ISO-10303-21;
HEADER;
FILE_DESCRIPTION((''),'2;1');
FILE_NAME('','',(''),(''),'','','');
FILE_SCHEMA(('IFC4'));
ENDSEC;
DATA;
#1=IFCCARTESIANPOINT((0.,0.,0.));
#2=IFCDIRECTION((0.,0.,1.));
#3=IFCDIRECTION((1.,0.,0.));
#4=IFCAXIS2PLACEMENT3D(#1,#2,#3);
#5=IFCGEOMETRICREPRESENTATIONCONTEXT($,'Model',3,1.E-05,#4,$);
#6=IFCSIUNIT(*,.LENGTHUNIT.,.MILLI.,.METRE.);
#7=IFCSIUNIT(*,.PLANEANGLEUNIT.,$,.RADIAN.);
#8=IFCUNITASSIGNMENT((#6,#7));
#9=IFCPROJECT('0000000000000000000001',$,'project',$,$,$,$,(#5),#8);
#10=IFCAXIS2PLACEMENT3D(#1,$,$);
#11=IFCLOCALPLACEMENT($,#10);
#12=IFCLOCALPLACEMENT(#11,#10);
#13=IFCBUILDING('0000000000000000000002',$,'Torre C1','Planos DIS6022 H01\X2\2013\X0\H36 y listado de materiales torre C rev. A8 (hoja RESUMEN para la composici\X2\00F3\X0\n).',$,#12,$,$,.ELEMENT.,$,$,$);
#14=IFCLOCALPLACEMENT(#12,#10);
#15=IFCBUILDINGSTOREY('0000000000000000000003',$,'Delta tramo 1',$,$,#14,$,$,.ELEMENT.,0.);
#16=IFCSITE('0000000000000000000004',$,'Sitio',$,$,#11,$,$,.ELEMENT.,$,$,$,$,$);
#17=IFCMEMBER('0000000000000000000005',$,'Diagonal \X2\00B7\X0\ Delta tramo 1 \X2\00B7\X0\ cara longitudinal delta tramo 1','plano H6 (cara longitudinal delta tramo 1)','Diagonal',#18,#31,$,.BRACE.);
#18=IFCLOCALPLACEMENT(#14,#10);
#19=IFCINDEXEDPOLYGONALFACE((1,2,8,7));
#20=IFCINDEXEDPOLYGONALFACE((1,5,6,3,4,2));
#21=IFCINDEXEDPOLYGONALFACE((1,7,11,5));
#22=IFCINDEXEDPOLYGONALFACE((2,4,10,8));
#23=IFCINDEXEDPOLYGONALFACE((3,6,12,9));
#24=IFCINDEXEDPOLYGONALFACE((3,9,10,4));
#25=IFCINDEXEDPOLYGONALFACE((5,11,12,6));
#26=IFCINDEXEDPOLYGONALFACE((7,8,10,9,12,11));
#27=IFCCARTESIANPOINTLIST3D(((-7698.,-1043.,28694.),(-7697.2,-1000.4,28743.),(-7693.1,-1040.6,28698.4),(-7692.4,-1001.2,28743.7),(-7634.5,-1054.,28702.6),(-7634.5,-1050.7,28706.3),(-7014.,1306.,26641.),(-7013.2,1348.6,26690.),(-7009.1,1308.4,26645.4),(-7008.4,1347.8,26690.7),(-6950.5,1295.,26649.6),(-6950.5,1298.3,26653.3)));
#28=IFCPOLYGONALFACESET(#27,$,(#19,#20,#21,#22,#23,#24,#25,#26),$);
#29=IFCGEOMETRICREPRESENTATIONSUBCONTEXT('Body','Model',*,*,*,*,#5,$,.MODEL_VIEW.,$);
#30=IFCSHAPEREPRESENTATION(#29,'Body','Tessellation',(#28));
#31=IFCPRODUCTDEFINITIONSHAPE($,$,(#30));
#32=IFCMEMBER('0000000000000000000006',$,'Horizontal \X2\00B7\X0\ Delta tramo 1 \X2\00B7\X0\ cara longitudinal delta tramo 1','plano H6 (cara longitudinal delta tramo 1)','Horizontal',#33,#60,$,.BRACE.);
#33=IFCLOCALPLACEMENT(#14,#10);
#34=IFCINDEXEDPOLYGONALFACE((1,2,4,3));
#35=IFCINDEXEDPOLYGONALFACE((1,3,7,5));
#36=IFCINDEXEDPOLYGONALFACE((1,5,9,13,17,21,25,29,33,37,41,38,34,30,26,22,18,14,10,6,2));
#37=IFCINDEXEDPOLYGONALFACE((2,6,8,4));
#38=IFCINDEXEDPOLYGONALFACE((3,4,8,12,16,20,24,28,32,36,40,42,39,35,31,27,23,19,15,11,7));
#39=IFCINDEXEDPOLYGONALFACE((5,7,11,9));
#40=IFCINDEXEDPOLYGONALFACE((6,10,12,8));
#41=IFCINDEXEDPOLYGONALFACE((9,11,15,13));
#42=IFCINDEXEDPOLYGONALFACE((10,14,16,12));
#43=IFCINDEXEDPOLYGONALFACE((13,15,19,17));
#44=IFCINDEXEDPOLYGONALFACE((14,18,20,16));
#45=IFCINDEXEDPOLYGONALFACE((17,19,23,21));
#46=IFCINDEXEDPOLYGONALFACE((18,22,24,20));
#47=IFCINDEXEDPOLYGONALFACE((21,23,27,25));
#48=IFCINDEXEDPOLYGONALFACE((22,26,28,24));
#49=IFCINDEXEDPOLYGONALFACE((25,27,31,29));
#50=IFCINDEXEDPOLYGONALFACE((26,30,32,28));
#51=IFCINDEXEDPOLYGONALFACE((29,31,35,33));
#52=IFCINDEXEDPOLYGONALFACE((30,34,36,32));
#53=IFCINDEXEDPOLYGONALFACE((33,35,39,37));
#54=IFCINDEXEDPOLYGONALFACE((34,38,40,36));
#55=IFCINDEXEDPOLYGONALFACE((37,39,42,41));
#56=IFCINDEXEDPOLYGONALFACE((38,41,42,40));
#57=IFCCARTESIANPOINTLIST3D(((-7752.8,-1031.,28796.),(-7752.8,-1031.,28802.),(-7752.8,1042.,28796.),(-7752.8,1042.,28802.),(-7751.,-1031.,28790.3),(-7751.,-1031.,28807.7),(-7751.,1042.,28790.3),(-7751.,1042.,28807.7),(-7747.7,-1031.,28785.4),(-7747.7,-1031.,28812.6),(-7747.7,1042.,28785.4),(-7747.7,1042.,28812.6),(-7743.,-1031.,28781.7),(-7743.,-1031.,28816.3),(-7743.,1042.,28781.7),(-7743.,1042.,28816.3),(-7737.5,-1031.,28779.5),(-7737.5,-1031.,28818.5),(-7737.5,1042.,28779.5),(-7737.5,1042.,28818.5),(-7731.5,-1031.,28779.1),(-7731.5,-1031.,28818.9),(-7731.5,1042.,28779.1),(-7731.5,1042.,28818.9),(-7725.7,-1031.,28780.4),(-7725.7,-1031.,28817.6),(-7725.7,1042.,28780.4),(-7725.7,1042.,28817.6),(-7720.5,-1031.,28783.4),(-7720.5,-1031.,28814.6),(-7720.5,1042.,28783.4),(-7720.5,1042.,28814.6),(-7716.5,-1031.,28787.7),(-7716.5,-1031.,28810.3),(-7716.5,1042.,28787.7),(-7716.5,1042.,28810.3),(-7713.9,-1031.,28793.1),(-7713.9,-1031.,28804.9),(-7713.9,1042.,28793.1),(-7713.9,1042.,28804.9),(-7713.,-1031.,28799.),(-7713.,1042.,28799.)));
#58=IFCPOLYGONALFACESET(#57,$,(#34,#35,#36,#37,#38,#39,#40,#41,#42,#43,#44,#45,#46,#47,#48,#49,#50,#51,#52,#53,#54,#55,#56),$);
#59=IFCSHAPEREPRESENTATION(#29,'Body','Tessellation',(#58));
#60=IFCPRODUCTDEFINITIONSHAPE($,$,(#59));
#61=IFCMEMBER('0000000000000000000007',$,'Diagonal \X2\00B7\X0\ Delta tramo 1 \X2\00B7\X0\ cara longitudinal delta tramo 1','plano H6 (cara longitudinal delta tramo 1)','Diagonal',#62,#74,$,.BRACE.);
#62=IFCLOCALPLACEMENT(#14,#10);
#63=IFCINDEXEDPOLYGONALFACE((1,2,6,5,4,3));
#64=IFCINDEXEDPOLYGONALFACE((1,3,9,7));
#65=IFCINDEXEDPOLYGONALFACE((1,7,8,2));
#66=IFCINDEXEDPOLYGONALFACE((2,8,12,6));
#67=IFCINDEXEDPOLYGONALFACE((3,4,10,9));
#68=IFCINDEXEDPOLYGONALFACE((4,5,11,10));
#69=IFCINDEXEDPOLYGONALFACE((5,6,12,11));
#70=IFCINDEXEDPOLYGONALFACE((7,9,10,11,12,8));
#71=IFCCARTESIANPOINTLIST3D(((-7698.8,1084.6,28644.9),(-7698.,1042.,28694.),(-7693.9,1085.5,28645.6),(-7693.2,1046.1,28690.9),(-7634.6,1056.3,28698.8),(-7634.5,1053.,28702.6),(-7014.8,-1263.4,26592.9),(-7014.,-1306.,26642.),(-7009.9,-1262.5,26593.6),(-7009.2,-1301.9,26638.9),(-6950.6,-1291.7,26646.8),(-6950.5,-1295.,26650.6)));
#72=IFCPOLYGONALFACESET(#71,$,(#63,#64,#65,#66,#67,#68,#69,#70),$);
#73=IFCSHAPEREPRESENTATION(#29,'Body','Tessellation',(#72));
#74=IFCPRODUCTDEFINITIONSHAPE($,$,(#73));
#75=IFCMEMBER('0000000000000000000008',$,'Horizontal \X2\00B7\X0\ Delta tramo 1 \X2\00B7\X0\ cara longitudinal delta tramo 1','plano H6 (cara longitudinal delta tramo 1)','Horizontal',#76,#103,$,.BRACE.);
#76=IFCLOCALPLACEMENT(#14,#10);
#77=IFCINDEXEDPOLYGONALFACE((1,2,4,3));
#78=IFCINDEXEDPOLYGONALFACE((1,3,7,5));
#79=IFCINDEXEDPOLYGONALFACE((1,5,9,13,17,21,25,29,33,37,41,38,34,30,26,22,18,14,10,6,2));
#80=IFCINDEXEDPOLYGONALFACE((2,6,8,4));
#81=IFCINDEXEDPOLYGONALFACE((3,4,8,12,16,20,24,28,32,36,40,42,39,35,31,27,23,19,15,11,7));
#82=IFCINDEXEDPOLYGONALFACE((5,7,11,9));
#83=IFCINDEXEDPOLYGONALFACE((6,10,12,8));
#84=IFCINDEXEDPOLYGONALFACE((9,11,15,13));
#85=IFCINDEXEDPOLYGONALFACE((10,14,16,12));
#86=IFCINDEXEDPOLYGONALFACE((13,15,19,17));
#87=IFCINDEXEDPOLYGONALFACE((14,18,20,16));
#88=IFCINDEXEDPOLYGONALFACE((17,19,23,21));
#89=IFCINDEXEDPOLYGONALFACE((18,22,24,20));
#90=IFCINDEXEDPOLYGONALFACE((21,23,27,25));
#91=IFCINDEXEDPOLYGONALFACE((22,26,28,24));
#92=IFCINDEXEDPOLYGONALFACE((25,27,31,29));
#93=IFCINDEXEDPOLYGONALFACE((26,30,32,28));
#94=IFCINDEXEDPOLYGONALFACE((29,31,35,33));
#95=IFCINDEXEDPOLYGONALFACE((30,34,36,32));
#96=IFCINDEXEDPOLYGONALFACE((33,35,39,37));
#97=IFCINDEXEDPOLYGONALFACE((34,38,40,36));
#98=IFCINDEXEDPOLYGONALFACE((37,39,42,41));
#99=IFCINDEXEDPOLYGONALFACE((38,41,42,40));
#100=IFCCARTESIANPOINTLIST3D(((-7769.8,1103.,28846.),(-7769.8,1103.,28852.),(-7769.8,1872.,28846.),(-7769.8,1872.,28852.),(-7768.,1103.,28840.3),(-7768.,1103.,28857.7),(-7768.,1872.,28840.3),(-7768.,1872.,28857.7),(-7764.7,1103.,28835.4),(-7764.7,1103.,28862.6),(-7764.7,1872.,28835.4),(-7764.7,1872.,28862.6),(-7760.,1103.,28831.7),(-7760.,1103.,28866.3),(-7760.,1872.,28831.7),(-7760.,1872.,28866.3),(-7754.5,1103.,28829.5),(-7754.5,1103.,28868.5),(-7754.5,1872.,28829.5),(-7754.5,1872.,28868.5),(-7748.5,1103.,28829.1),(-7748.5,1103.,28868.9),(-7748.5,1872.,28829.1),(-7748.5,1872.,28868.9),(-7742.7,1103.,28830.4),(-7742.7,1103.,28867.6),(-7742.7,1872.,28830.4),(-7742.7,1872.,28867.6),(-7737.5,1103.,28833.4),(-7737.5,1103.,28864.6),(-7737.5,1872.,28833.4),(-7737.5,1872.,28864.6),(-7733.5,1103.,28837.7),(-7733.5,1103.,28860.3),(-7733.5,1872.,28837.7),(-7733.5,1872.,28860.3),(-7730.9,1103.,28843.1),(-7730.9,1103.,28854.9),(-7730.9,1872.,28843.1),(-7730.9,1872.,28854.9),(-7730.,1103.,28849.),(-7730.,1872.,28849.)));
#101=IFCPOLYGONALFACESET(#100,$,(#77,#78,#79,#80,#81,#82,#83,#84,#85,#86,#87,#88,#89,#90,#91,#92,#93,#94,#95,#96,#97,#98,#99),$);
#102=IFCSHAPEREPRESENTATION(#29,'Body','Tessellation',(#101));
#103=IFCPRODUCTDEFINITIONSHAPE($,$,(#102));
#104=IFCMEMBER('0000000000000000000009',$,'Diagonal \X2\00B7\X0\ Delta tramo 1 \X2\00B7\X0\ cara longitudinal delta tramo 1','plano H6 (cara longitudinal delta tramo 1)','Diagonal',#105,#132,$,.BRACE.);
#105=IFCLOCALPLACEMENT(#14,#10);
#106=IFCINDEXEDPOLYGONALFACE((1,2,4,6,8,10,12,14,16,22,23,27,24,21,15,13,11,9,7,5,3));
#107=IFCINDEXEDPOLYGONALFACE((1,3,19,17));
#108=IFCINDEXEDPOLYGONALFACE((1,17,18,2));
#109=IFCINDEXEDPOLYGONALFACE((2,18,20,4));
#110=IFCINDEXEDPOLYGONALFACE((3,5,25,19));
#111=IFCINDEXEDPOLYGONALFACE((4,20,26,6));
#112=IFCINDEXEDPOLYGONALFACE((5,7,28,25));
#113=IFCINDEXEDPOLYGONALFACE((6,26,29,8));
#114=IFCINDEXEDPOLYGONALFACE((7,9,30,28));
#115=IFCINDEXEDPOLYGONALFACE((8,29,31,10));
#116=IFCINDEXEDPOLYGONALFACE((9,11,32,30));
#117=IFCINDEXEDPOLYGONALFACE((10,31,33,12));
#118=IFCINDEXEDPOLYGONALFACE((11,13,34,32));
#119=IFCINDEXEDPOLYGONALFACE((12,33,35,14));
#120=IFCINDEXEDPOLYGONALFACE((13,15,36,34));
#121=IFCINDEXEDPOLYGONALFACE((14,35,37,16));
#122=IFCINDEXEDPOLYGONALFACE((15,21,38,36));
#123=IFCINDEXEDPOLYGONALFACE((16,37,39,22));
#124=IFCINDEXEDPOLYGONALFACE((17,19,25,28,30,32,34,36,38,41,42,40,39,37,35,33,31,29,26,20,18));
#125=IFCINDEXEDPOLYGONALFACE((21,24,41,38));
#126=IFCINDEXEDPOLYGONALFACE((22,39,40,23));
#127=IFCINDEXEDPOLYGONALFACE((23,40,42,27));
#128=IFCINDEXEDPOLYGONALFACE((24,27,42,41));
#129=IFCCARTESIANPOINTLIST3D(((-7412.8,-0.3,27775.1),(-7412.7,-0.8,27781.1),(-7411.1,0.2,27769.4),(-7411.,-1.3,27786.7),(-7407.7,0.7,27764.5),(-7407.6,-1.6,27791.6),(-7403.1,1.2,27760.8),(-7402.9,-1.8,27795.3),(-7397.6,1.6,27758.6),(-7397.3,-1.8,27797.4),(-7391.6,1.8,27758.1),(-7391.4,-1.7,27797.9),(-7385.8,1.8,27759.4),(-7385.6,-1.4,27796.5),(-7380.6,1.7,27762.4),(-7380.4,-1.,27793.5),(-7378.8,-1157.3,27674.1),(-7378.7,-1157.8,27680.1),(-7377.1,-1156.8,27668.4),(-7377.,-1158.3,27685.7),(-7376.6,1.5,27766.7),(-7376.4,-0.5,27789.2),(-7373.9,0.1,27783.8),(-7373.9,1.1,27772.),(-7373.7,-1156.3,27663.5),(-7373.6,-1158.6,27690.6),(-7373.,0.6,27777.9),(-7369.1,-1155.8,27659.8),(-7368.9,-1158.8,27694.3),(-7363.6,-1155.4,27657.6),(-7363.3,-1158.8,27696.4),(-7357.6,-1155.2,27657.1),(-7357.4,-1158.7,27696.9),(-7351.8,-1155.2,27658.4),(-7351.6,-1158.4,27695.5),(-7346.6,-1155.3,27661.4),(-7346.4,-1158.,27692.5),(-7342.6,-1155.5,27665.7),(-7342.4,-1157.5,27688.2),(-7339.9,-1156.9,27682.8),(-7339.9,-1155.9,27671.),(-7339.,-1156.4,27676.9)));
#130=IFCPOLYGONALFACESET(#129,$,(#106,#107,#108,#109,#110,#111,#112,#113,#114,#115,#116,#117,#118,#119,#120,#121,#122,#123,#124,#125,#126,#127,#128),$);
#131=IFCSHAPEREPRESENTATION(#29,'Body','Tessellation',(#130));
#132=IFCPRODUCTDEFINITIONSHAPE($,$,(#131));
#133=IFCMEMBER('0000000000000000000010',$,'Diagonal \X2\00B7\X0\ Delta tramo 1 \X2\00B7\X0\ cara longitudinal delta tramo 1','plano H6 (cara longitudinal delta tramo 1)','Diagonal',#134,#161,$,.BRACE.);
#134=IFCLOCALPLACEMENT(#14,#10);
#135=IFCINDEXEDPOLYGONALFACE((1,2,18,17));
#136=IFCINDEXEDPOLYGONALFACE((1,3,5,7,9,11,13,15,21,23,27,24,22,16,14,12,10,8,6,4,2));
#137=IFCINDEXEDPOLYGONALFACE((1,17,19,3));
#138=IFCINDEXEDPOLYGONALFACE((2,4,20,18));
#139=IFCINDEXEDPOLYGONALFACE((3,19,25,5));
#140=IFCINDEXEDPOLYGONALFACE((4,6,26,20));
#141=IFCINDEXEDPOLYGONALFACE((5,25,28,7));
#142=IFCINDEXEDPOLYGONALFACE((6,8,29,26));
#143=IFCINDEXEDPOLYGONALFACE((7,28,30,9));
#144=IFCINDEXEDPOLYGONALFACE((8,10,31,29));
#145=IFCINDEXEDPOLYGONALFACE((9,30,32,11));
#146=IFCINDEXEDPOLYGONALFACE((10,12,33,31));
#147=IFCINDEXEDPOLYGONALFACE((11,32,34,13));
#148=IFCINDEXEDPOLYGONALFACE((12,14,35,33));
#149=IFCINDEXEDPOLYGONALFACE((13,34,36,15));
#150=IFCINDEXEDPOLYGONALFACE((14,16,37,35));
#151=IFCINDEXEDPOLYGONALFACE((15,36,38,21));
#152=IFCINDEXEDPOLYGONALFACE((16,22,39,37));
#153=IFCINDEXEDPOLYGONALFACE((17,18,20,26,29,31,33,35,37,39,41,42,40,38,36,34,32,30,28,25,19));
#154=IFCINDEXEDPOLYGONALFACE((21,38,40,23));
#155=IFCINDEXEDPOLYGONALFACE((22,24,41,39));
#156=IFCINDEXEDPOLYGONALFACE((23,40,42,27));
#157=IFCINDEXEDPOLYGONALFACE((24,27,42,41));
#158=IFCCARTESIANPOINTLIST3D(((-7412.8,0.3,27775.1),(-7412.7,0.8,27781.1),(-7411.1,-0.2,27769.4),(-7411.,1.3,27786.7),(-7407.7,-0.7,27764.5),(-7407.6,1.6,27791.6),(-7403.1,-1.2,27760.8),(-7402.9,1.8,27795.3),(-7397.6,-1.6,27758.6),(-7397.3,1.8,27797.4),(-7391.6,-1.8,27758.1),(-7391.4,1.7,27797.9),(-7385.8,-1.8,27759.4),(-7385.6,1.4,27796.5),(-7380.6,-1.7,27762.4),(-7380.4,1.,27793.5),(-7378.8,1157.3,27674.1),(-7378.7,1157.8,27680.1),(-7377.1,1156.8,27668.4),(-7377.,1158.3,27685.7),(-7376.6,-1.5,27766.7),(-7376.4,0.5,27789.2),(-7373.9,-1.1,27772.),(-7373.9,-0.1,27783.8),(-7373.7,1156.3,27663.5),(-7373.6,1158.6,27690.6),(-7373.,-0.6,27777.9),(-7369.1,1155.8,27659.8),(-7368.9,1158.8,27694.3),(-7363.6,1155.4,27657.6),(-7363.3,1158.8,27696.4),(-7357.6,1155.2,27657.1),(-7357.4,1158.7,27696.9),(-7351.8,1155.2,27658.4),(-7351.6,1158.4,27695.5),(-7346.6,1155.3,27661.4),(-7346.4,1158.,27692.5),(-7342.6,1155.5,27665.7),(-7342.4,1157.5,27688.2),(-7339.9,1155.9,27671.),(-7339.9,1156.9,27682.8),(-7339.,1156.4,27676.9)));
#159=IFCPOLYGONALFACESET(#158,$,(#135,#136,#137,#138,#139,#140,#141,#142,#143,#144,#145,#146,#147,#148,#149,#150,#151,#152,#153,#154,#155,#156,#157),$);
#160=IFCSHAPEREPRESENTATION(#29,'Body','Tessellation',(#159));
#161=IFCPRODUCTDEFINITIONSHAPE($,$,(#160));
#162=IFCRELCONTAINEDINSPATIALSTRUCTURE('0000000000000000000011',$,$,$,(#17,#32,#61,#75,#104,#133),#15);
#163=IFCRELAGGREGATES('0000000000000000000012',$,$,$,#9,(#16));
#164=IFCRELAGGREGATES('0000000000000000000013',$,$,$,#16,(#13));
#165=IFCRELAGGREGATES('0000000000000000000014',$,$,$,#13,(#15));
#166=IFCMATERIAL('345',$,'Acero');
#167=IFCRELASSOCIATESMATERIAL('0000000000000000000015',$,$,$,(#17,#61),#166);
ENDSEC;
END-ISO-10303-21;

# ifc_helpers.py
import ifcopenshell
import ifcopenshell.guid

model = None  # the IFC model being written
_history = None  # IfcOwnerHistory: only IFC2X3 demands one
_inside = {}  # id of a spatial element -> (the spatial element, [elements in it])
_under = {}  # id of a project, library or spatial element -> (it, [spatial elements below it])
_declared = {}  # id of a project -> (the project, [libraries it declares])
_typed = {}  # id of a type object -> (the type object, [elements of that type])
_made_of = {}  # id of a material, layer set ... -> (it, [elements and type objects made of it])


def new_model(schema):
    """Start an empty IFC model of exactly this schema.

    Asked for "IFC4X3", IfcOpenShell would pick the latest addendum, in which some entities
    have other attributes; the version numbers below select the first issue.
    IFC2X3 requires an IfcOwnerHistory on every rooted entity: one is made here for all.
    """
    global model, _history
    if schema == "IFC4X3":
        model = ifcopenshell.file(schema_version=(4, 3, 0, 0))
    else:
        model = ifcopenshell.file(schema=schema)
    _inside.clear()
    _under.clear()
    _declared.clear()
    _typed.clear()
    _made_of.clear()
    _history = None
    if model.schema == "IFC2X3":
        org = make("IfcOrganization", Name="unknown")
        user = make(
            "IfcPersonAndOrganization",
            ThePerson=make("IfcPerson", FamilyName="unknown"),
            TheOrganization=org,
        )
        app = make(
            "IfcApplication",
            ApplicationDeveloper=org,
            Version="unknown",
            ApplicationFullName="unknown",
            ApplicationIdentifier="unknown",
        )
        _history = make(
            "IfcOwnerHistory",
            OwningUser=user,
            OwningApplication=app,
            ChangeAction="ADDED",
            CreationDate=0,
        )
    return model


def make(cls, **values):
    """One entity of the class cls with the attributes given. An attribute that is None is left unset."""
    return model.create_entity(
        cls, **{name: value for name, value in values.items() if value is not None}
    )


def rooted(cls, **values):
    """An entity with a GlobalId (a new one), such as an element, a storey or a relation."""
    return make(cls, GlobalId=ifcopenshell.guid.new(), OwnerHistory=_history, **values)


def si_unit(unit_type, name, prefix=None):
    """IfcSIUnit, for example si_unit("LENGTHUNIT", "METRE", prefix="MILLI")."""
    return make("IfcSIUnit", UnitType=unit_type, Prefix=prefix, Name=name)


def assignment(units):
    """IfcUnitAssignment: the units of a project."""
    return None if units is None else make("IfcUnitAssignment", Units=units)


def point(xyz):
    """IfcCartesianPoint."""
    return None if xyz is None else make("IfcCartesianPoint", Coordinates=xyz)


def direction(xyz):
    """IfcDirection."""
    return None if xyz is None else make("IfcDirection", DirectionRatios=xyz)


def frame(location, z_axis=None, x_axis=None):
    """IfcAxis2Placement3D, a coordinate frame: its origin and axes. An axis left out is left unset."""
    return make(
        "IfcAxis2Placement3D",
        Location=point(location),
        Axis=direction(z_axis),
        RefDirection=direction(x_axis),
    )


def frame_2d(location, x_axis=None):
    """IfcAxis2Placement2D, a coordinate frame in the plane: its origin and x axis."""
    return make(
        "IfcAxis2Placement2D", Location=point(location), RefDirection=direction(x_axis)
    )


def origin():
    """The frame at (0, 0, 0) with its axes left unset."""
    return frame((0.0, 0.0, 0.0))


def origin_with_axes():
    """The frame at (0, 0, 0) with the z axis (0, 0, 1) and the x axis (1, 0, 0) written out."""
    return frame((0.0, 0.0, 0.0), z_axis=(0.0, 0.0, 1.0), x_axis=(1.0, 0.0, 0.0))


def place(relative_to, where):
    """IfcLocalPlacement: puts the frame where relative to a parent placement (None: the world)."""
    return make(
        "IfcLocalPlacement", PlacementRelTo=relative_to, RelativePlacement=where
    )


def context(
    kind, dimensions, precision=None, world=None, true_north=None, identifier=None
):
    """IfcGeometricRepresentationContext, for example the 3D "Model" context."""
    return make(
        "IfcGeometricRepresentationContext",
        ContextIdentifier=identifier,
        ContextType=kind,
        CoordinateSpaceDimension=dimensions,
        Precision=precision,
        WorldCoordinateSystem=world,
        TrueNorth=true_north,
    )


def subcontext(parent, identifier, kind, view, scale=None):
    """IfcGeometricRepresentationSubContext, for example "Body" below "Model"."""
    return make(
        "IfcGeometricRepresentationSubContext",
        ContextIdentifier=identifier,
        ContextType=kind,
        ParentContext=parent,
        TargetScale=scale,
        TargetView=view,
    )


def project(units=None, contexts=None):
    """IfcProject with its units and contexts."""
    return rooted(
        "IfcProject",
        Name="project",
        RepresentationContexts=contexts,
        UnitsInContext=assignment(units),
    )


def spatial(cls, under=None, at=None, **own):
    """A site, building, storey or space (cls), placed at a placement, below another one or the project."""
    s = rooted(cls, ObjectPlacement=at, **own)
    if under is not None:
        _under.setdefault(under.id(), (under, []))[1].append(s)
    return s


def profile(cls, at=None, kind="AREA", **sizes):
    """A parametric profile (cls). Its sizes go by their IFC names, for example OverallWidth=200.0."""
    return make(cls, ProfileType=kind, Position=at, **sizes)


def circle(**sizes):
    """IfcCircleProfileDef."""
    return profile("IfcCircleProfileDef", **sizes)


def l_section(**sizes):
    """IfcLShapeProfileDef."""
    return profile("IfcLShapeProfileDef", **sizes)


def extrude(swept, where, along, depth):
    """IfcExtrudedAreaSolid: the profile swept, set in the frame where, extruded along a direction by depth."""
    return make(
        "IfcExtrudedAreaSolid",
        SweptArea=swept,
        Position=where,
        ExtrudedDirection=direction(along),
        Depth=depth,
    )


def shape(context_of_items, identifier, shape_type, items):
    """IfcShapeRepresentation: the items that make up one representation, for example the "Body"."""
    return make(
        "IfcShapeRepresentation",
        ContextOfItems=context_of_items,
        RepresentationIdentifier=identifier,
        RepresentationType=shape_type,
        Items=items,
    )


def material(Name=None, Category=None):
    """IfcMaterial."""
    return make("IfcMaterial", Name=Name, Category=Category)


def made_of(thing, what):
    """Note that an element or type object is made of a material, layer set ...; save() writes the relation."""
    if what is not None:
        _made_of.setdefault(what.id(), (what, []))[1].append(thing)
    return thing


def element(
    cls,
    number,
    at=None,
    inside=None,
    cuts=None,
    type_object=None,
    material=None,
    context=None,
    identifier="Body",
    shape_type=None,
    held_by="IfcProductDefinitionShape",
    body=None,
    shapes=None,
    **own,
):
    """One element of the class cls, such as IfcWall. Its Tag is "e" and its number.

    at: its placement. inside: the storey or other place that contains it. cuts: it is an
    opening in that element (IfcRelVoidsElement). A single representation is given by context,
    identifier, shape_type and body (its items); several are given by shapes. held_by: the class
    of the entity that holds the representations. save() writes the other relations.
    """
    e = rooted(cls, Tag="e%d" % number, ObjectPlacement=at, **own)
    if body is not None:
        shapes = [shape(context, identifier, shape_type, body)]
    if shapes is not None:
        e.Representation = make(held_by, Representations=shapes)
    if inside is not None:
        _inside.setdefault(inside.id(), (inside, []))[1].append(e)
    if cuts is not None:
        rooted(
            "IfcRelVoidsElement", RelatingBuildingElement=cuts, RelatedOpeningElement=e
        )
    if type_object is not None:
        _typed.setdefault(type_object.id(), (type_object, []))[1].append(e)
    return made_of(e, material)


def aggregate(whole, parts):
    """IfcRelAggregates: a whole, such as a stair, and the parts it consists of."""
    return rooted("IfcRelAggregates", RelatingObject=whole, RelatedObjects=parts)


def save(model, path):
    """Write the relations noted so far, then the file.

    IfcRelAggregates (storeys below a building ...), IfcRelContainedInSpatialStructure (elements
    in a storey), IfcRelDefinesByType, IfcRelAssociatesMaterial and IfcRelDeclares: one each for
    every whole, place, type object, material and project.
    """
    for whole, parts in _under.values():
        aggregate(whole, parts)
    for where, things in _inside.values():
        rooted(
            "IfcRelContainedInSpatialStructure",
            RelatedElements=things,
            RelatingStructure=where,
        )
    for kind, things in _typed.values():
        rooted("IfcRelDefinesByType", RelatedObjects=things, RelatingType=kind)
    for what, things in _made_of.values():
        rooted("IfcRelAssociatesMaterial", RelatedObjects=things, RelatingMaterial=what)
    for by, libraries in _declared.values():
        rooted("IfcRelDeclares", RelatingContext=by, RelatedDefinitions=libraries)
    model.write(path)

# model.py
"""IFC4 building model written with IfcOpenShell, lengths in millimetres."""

from ifc_helpers import new_model, si_unit, frame, frame_2d, origin, origin_with_axes, place, context, subcontext, project, spatial, circle, l_section, extrude, material, element, save


model = new_model("IFC4")

# Units and contexts
model_context = context("Model", 3, precision=1e-05, world=origin_with_axes())
body_context = subcontext(model_context, "Body", "Model", "MODEL_VIEW")
ifc_project = project(units=[si_unit("LENGTHUNIT", "METRE", prefix="MILLI"), si_unit("PLANEANGLEUNIT", "RADIAN")], contexts=[model_context])

# Site, building, storey
site_placement = place(None, origin())
site = spatial("IfcSite", under=ifc_project, at=site_placement, Name="Sitio", CompositionType="ELEMENT")
building_placement = place(site_placement, origin())
building = spatial("IfcBuilding", under=site, at=building_placement, Name="Torre C1", Description="Planos DIS6022 H01–H36 y listado de materiales torre C rev. A8 (hoja RESUMEN para la composición).", CompositionType="ELEMENT")
storey_placement = place(building_placement, origin())
storey = spatial("IfcBuildingStorey", under=building, at=storey_placement, Name="Delta tramo 1", CompositionType="ELEMENT", Elevation=0.0)

# Members
ifc_material = material(Name="345", Category="Acero")
member_1_placement = place(storey_placement, frame((-7014.0, 1306.0, 26641.0), z_axis=(-0.214164, -0.735484, 0.642805), x_axis=(0.976727, -0.169145, 0.131884)))
element("IfcMember", 1, at=member_1_placement, inside=storey, material=ifc_material, Name="Diagonal · Delta tramo 1 · cara longitudinal delta tramo 1", Description="plano H6 (cara longitudinal delta tramo 1)", ObjectType="Diagonal", PredefinedType="BRACE", context=body_context, shape_type="SweptSolid", body=[
    extrude(l_section(Depth=65.0, Width=65.0, Thickness=5.0, at=frame_2d((32.5, 32.5))), None, (0.0, 0.0, 1.0), 3193.8),
])
member_2_placement = place(storey_placement, frame((-7733.0, -1031.0, 28799.0), z_axis=(0.0, 1.0, 0.0), x_axis=(1.0, 0.0, 0.0)))
element("IfcMember", 2, at=member_2_placement, inside=storey, Name="Horizontal · Delta tramo 1 · cara longitudinal delta tramo 1", Description="plano H6 (cara longitudinal delta tramo 1)", ObjectType="Horizontal", PredefinedType="BRACE", context=body_context, shape_type="SweptSolid", body=[
    extrude(circle(Radius=20.0), None, (0.0, 0.0, 1.0), 2073.0),
])
member_3_placement = place(storey_placement, frame((-7014.0, -1306.0, 26642.0), z_axis=(-0.214256, 0.735488, 0.642769), x_axis=(0.976707, 0.169249, 0.131906)))
element("IfcMember", 3, at=member_3_placement, inside=storey, material=ifc_material, Name="Diagonal · Delta tramo 1 · cara longitudinal delta tramo 1", Description="plano H6 (cara longitudinal delta tramo 1)", ObjectType="Diagonal", PredefinedType="BRACE", context=body_context, shape_type="SweptSolid", body=[
    extrude(l_section(Depth=65.0, Width=65.0, Thickness=5.0, at=frame_2d((32.5, 32.5))), None, (0.0, 0.0, 1.0), 3192.4),
])
member_4_placement = place(storey_placement, frame((-7750.0, 1103.0, 28849.0), z_axis=(0.0, 1.0, 0.0), x_axis=(1.0, 0.0, 0.0)))
element("IfcMember", 4, at=member_4_placement, inside=storey, Name="Horizontal · Delta tramo 1 · cara longitudinal delta tramo 1", Description="plano H6 (cara longitudinal delta tramo 1)", ObjectType="Horizontal", PredefinedType="BRACE", context=body_context, shape_type="SweptSolid", body=[
    extrude(circle(Radius=20.0), None, (0.0, 0.0, 1.0), 769.0),
])
for number, where, z_axis, x_axis, name in (
    (5, (-7359.0, -1157.0, 27677.0), (-0.029262, 0.995785, 0.086927), (0.999549, 0.029743, -0.004237), "Diagonal · Delta tramo 1 · cara longitudinal delta tramo 1"),
    (6, (-7359.0, 1157.0, 27677.0), (-0.029262, -0.995785, 0.086927), (0.999549, -0.029743, -0.004237), "Diagonal · Delta tramo 1 · cara longitudinal delta tramo 1"),
):
    element("IfcMember", number, at=place(storey_placement, frame(where, z_axis=z_axis, x_axis=x_axis)), inside=storey, Name=name, Description="plano H6 (cara longitudinal delta tramo 1)", ObjectType="Diagonal", PredefinedType="BRACE", context=body_context, shape_type="SweptSolid", body=[
        extrude(circle(Radius=20.0), None, (0.0, 0.0, 1.0), 1161.9),
    ])

save(model, "model.ifc")
